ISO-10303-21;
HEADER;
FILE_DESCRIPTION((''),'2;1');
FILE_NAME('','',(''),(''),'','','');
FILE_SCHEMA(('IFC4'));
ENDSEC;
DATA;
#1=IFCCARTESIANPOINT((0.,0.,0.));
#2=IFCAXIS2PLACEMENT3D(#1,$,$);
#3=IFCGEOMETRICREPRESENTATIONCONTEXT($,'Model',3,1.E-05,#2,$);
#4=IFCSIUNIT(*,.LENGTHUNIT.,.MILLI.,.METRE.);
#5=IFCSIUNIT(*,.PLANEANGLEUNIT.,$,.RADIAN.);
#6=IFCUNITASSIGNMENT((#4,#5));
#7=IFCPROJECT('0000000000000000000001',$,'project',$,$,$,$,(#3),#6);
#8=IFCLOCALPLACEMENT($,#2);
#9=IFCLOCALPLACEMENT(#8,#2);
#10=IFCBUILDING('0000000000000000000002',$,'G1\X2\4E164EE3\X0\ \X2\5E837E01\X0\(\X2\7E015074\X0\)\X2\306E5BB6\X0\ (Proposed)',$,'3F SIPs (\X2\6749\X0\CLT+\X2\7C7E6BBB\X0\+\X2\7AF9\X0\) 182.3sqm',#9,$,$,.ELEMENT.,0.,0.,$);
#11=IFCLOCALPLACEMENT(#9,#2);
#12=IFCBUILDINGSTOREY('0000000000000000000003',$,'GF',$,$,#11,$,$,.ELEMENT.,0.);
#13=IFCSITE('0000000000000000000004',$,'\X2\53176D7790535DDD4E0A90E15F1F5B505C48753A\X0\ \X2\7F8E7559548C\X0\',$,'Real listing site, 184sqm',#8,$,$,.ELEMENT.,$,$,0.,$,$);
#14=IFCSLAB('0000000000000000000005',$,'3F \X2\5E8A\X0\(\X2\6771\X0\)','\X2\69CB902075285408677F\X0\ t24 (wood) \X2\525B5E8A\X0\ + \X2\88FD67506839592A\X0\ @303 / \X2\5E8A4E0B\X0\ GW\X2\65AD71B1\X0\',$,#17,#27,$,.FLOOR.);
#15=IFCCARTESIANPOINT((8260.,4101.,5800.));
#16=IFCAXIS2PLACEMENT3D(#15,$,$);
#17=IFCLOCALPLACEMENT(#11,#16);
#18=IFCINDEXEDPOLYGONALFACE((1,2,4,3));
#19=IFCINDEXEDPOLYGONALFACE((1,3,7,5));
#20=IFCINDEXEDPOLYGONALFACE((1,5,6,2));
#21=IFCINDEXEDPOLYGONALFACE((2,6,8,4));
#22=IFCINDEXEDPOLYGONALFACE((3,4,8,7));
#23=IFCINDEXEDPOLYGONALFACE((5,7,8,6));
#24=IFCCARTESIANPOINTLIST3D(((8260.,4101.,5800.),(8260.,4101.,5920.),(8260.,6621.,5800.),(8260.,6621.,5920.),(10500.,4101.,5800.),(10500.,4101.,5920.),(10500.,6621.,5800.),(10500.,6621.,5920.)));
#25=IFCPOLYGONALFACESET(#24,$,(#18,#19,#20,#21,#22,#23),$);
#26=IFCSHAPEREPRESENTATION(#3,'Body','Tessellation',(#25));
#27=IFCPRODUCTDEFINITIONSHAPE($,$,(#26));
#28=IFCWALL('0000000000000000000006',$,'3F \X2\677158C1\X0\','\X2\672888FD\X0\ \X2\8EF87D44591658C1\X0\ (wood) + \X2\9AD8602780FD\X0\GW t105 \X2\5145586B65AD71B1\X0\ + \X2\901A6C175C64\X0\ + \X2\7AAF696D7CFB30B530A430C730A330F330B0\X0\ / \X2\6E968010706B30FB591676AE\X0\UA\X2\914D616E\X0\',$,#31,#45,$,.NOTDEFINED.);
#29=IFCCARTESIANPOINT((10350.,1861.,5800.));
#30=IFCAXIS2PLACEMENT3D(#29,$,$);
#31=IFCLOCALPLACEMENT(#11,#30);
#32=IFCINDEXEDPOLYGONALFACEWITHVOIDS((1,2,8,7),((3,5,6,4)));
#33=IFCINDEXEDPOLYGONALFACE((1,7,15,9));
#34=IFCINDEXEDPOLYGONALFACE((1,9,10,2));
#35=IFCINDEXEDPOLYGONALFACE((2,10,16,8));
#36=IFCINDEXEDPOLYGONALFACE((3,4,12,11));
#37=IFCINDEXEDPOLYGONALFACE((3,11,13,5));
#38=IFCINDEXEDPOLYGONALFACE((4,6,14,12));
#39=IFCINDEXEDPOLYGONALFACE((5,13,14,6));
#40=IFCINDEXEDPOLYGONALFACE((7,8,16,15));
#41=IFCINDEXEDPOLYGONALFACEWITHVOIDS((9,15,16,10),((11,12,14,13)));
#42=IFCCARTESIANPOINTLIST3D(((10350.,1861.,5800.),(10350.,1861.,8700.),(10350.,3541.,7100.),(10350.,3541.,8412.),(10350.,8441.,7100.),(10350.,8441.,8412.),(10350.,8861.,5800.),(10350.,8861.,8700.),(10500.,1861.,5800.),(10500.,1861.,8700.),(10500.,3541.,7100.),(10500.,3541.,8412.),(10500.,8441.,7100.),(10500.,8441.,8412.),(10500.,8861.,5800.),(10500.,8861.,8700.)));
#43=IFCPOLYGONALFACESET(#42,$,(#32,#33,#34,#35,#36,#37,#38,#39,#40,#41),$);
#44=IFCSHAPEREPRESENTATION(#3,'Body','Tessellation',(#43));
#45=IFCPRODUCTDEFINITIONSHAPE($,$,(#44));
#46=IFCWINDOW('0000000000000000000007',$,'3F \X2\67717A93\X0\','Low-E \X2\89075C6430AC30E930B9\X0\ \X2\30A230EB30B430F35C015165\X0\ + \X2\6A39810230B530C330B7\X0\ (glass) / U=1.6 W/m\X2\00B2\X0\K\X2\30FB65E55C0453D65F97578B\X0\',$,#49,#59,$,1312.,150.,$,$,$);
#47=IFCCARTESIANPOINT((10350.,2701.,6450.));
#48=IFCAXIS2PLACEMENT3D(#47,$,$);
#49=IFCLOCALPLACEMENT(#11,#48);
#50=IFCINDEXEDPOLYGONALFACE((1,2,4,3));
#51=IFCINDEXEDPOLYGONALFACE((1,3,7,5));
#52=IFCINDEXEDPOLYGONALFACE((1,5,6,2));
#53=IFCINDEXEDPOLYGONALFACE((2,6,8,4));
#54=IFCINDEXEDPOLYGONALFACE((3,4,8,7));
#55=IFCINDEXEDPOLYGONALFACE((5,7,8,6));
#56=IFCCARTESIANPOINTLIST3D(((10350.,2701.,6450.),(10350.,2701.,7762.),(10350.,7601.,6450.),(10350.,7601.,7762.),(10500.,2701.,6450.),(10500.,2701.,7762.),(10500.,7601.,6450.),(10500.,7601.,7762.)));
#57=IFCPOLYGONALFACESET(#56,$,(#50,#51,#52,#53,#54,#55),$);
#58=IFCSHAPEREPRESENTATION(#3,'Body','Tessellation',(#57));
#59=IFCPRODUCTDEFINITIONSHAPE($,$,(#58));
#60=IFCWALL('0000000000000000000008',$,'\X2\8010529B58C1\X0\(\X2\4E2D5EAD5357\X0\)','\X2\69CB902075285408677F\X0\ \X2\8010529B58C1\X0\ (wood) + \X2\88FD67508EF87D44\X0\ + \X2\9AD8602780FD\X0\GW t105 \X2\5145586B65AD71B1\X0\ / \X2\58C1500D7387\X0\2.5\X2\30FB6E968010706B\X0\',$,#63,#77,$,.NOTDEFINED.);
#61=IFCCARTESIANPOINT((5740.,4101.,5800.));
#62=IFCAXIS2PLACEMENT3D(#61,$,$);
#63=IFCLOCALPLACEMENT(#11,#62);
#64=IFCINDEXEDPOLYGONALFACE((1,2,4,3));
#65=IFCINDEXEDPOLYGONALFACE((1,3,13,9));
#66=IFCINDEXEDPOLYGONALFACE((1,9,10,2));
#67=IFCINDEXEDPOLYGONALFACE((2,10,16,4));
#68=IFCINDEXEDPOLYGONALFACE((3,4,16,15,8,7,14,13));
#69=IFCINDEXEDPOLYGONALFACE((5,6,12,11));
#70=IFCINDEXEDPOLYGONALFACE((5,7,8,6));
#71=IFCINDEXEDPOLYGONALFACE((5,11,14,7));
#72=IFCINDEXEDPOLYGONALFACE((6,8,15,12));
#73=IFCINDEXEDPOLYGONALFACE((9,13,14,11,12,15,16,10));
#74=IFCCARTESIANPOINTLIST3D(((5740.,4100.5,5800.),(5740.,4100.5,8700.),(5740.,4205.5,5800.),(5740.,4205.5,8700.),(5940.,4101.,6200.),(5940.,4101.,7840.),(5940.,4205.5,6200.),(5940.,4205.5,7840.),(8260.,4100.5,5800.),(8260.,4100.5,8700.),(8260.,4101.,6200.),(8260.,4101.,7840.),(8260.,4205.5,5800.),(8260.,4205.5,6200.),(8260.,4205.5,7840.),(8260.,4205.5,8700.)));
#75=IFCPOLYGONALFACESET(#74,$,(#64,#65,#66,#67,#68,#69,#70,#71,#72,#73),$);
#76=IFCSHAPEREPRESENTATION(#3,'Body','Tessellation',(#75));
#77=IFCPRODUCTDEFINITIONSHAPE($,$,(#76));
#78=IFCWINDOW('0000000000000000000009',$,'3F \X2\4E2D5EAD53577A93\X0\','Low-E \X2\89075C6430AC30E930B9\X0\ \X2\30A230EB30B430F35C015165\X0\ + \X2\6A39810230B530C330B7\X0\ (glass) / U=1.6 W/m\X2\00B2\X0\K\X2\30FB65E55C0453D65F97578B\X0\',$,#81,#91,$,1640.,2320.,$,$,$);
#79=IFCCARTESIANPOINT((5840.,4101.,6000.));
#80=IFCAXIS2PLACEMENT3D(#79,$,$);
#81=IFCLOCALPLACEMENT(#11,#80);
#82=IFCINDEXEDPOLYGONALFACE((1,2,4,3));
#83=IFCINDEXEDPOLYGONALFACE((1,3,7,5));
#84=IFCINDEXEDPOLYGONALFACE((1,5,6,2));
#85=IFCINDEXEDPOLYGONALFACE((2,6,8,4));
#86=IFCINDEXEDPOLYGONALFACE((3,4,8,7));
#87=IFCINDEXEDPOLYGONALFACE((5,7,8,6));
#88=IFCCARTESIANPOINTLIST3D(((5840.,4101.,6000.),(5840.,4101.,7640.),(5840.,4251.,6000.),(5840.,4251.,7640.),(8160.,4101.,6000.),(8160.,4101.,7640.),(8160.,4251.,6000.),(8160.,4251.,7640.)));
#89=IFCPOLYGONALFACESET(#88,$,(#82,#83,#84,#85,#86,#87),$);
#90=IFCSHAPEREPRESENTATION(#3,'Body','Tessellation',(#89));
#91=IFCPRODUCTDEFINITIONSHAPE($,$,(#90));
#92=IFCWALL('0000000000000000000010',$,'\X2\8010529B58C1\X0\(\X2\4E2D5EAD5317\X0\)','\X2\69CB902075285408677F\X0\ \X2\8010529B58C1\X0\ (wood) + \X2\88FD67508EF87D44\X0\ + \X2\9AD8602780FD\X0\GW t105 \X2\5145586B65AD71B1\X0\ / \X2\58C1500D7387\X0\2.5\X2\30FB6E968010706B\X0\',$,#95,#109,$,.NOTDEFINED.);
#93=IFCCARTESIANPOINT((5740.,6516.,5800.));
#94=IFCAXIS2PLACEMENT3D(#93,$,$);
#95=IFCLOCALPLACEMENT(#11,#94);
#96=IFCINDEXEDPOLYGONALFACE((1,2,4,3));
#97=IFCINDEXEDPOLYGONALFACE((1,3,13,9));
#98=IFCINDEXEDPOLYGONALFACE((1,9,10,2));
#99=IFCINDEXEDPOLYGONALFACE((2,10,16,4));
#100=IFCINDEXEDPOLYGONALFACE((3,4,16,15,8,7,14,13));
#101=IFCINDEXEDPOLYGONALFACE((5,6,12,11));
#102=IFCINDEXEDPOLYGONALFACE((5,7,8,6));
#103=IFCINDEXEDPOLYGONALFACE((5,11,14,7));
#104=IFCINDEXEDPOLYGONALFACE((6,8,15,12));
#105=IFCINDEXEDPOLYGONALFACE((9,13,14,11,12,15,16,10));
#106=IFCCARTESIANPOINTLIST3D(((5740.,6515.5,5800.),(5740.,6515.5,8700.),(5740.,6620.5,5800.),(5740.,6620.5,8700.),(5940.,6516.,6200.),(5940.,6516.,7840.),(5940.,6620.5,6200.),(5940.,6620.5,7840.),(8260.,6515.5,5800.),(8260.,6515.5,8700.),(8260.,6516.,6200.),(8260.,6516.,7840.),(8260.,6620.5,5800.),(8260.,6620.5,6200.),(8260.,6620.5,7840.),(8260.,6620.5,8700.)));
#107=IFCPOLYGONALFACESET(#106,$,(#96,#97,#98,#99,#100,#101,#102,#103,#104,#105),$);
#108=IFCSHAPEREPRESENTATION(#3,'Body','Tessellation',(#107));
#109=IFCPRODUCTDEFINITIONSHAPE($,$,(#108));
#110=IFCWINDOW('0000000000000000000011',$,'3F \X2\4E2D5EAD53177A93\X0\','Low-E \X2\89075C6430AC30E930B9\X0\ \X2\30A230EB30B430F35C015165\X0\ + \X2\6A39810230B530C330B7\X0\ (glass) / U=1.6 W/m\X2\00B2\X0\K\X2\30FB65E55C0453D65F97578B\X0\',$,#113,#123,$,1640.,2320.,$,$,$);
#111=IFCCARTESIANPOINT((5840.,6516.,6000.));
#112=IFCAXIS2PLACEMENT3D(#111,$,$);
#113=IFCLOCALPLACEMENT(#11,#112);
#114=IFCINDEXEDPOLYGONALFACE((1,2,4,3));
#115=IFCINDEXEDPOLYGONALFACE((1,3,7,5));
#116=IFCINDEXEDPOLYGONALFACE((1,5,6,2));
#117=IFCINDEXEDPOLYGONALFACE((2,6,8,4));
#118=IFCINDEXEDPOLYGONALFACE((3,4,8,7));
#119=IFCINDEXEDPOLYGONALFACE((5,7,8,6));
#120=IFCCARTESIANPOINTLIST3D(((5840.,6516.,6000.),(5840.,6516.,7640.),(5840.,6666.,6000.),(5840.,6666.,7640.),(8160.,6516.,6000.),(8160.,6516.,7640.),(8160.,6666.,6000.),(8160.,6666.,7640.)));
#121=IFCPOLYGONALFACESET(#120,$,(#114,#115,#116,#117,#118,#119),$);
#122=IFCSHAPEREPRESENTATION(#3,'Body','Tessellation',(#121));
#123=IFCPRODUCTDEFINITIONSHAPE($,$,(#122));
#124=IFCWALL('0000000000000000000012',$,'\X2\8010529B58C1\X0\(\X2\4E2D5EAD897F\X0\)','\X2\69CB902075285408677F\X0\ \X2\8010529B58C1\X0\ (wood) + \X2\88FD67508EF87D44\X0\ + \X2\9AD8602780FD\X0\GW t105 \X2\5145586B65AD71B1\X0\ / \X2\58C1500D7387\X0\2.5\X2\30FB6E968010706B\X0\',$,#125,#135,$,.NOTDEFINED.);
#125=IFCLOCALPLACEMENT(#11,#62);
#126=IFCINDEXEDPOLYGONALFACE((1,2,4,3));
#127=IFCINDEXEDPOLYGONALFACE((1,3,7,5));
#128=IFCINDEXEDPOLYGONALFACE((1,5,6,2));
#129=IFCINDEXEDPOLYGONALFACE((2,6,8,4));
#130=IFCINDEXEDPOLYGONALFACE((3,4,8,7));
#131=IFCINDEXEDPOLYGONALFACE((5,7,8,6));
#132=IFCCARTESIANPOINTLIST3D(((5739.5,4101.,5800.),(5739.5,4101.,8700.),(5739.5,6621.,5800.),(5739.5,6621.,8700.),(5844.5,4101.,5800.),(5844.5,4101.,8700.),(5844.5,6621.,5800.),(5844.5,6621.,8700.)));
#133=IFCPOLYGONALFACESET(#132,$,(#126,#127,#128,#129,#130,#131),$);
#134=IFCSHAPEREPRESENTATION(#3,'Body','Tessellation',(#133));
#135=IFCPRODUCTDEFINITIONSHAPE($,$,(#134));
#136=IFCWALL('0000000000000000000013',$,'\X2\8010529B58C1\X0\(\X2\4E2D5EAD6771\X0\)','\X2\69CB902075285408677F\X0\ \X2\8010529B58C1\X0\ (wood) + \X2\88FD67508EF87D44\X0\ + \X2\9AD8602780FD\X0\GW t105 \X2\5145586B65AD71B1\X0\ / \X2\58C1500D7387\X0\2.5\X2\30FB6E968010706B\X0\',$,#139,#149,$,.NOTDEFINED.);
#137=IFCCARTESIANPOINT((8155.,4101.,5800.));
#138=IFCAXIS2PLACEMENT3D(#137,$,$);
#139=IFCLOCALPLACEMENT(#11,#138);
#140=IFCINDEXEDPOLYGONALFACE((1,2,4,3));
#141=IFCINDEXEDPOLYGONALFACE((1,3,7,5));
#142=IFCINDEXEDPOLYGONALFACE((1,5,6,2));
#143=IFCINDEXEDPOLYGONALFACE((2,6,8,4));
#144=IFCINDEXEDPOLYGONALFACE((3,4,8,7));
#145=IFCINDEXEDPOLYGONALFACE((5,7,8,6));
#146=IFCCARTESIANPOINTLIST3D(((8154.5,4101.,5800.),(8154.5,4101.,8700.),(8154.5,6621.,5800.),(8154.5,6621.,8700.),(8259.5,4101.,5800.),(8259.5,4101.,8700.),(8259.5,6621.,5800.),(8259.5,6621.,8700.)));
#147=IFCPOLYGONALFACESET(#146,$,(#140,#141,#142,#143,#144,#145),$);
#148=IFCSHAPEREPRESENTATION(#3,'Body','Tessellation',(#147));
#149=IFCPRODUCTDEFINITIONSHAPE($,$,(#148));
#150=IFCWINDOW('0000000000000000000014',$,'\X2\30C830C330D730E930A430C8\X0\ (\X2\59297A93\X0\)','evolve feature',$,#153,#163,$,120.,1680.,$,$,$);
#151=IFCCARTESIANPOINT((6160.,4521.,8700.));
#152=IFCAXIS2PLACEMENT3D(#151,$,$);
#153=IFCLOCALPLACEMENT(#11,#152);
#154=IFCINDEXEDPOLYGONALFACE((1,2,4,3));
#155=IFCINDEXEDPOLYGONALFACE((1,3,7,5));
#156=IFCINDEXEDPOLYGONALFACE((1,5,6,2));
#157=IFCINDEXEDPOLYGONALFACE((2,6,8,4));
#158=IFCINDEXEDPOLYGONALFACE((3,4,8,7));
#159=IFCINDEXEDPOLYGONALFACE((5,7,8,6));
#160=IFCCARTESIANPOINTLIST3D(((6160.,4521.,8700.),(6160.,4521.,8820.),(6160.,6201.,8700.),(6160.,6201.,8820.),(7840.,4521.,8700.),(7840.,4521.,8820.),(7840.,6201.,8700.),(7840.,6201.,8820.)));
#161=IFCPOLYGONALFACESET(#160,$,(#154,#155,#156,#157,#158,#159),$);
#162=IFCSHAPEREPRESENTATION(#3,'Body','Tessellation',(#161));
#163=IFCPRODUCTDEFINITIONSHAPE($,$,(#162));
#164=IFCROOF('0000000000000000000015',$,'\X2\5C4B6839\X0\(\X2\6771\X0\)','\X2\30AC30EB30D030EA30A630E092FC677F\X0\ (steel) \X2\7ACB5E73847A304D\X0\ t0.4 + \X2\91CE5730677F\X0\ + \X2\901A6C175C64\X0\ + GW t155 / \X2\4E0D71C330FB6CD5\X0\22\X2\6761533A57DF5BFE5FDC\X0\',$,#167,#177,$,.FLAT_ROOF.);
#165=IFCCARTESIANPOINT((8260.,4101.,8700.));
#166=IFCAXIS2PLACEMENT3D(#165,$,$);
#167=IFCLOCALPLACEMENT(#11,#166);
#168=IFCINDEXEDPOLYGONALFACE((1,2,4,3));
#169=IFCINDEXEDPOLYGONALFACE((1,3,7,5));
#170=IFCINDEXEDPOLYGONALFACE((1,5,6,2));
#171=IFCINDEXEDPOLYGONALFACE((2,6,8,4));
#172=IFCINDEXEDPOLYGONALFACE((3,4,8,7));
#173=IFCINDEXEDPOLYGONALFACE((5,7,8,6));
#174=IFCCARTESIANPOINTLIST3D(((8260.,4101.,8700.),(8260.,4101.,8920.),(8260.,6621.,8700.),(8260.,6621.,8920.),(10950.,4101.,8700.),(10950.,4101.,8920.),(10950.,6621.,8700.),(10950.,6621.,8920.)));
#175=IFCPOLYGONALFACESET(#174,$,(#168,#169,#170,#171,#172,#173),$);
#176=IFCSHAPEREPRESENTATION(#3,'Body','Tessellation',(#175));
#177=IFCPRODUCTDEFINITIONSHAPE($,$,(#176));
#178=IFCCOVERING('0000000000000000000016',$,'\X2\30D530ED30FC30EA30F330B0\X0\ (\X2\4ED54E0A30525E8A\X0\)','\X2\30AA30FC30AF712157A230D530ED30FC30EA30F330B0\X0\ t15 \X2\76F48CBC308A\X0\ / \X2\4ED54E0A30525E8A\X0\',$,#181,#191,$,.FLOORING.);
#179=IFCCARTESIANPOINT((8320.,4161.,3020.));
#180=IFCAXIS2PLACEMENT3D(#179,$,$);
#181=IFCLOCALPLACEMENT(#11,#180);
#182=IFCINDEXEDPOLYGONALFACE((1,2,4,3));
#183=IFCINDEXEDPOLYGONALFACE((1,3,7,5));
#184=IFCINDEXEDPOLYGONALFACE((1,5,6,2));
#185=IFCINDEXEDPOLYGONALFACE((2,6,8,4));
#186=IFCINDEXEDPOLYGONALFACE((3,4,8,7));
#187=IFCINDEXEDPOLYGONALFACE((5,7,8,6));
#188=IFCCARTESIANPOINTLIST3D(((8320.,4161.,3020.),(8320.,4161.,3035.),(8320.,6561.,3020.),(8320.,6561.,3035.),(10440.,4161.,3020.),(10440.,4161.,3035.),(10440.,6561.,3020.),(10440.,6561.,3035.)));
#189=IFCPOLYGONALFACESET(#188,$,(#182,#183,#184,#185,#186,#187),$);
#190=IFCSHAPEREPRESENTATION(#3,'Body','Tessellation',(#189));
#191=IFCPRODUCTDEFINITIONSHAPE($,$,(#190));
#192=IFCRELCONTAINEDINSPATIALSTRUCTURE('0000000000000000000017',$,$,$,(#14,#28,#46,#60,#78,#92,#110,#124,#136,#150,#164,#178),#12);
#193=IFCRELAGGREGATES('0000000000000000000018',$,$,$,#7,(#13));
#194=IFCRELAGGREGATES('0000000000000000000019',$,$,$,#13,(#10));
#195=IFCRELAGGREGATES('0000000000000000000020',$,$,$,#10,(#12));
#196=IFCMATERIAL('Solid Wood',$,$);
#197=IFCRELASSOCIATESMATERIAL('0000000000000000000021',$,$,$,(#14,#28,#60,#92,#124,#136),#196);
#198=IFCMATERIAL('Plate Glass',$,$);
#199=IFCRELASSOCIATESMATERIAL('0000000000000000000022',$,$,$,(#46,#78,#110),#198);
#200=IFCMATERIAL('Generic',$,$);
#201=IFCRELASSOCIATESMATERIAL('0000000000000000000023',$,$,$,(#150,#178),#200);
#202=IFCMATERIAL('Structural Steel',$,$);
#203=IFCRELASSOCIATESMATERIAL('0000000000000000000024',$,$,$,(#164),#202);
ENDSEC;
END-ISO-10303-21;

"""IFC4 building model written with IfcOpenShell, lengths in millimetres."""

from ifc_helpers import new_model, si_unit, frame, frame_2d, origin, place, context, project, spatial, rectangle, extrude, material, element, fill, save


model = new_model("IFC4")

# Units and contexts
model_context = context("Model", 3, precision=1e-05, world=origin())
ifc_project = project(units=[si_unit("LENGTHUNIT", "METRE", prefix="MILLI"), si_unit("PLANEANGLEUNIT", "RADIAN")], contexts=[model_context])

# Site, building, storey
site_placement = place(None, origin())
site = spatial("IfcSite", under=ifc_project, at=site_placement, Name="北海道川上郡弟子屈町 美留和", ObjectType="Real listing site, 184sqm", CompositionType="ELEMENT", RefElevation=0.0)
building_placement = place(site_placement, origin())
building = spatial("IfcBuilding", under=site, at=building_placement, Name="G1世代 広縁(縁側)の家 (Proposed)", ObjectType="3F SIPs (杉CLT+籾殻+竹) 182.3sqm", CompositionType="ELEMENT", ElevationOfRefHeight=0.0, ElevationOfTerrain=0.0)
storey_placement = place(building_placement, origin())
storey = spatial("IfcBuildingStorey", under=building, at=storey_placement, Name="GF", CompositionType="ELEMENT", Elevation=0.0)

# Slab
ifc_material_1 = material(Name="Solid Wood")
slab_placement = place(storey_placement, frame((8260.0, 4101.0, 5800.0)))
element("IfcSlab", 1, at=slab_placement, inside=storey, material=ifc_material_1, Name="3F 床(東)", Description="構造用合板 t24 (wood) 剛床 + 製材根太 @303 / 床下 GW断熱", PredefinedType="FLOOR", context=model_context, shape_type="SweptSolid", body=[
    extrude(rectangle(XDim=2240.0, YDim=2520.0, at=frame_2d((1120.0, 1260.0))), frame((8260.0, 4101.0, 5800.0)), (0.0, 0.0, 1.0), 120.0),
])

# Walls, openings, windows
wall_1_placement = place(storey_placement, frame((10350.0, 1861.0, 5800.0)))
wall_1 = element("IfcWall", 2, at=wall_1_placement, inside=storey, material=ifc_material_1, Name="3F 東壁", Description="木製 軸組外壁 (wood) + 高性能GW t105 充填断熱 + 通気層 + 窯業系サイディング / 準耐火・外皮UA配慮", PredefinedType="NOTDEFINED", context=model_context, shape_type="SweptSolid", body=[
    extrude(rectangle(XDim=150.0, YDim=7000.0, at=frame_2d((75.0, 3500.0))), frame((10350.0, 1861.0, 5800.0)), (0.0, 0.0, 1.0), 2900.0),
])
opening_1_placement = place(storey_placement, frame((10350.0, 2701.0, 6450.0)))
opening_1 = element("IfcOpeningElement", 3, at=opening_1_placement, cuts=wall_1, PredefinedType="NOTDEFINED", context=model_context, shape_type="SweptSolid", body=[
    extrude(rectangle(XDim=150.0, YDim=4900.0, at=frame_2d((75.0, 2450.0))), frame((10350.0, 2701.0, 6450.0)), (0.0, 0.0, 1.0), 1312.0),
])
ifc_material_2 = material(Name="Plate Glass")
window_1_placement = place(storey_placement, frame((10350.0, 2701.0, 6450.0)))
window_1 = element("IfcWindow", 4, at=window_1_placement, inside=storey, material=ifc_material_2, Name="3F 東窓", Description="Low-E 複層ガラス アルゴン封入 + 樹脂サッシ (glass) / U=1.6 W/m²K・日射取得型", OverallHeight=1312.0, OverallWidth=150.0, context=model_context, shape_type="SweptSolid", body=[
    extrude(rectangle(XDim=150.0, YDim=4900.0, at=frame_2d((75.0, 2450.0))), frame((10350.0, 2701.0, 6450.0)), (0.0, 0.0, 1.0), 1312.0),
])
fill(opening_1, window_1)
wall_2_placement = place(storey_placement, frame((5740.0, 4101.0, 5800.0)))
wall_2 = element("IfcWall", 5, at=wall_2_placement, inside=storey, material=ifc_material_1, Name="耐力壁(中庭南)", Description="構造用合板 耐力壁 (wood) + 製材軸組 + 高性能GW t105 充填断熱 / 壁倍率2.5・準耐火", PredefinedType="NOTDEFINED", context=model_context, shape_type="SweptSolid", body=[
    extrude(rectangle(XDim=2520.0, YDim=105.0, at=frame_2d((1260.0, 52.0))), frame((5740.0, 4101.0, 5800.0)), (0.0, 0.0, 1.0), 2900.0),
])
opening_2_placement = place(storey_placement, frame((5840.0, 4101.0, 6000.0)))
opening_2 = element("IfcOpeningElement", 6, at=opening_2_placement, cuts=wall_2, PredefinedType="NOTDEFINED", context=model_context, shape_type="SweptSolid", body=[
    extrude(rectangle(XDim=2320.0, YDim=150.0, at=frame_2d((1160.0, 75.0))), frame((5840.0, 4101.0, 6000.0)), (0.0, 0.0, 1.0), 1640.0),
])
window_2_placement = place(storey_placement, frame((5840.0, 4101.0, 6000.0)))
window_2 = element("IfcWindow", 7, at=window_2_placement, inside=storey, material=ifc_material_2, Name="3F 中庭南窓", Description="Low-E 複層ガラス アルゴン封入 + 樹脂サッシ (glass) / U=1.6 W/m²K・日射取得型", OverallHeight=1640.0, OverallWidth=2320.0, context=model_context, shape_type="SweptSolid", body=[
    extrude(rectangle(XDim=2320.0, YDim=150.0, at=frame_2d((1160.0, 75.0))), frame((5840.0, 4101.0, 6000.0)), (0.0, 0.0, 1.0), 1640.0),
])
fill(opening_2, window_2)
wall_3_placement = place(storey_placement, frame((5740.0, 6516.0, 5800.0)))
wall_3 = element("IfcWall", 8, at=wall_3_placement, inside=storey, material=ifc_material_1, Name="耐力壁(中庭北)", Description="構造用合板 耐力壁 (wood) + 製材軸組 + 高性能GW t105 充填断熱 / 壁倍率2.5・準耐火", PredefinedType="NOTDEFINED", context=model_context, shape_type="SweptSolid", body=[
    extrude(rectangle(XDim=2520.0, YDim=105.0, at=frame_2d((1260.0, 52.0))), frame((5740.0, 6516.0, 5800.0)), (0.0, 0.0, 1.0), 2900.0),
])
opening_3_placement = place(storey_placement, frame((5840.0, 6516.0, 6000.0)))
opening_3 = element("IfcOpeningElement", 9, at=opening_3_placement, cuts=wall_3, PredefinedType="NOTDEFINED", context=model_context, shape_type="SweptSolid", body=[
    extrude(rectangle(XDim=2320.0, YDim=150.0, at=frame_2d((1160.0, 75.0))), frame((5840.0, 6516.0, 6000.0)), (0.0, 0.0, 1.0), 1640.0),
])
window_3_placement = place(storey_placement, frame((5840.0, 6516.0, 6000.0)))
window_3 = element("IfcWindow", 10, at=window_3_placement, inside=storey, material=ifc_material_2, Name="3F 中庭北窓", Description="Low-E 複層ガラス アルゴン封入 + 樹脂サッシ (glass) / U=1.6 W/m²K・日射取得型", OverallHeight=1640.0, OverallWidth=2320.0, context=model_context, shape_type="SweptSolid", body=[
    extrude(rectangle(XDim=2320.0, YDim=150.0, at=frame_2d((1160.0, 75.0))), frame((5840.0, 6516.0, 6000.0)), (0.0, 0.0, 1.0), 1640.0),
])
fill(opening_3, window_3)

# Walls
wall_4_placement = place(storey_placement, frame((5740.0, 4101.0, 5800.0)))
element("IfcWall", 11, at=wall_4_placement, inside=storey, material=ifc_material_1, Name="耐力壁(中庭西)", Description="構造用合板 耐力壁 (wood) + 製材軸組 + 高性能GW t105 充填断熱 / 壁倍率2.5・準耐火", PredefinedType="NOTDEFINED", context=model_context, shape_type="SweptSolid", body=[
    extrude(rectangle(XDim=105.0, YDim=2520.0, at=frame_2d((52.0, 1260.0))), frame((5740.0, 4101.0, 5800.0)), (0.0, 0.0, 1.0), 2900.0),
])
wall_5_placement = place(storey_placement, frame((8155.0, 4101.0, 5800.0)))
element("IfcWall", 12, at=wall_5_placement, inside=storey, material=ifc_material_1, Name="耐力壁(中庭東)", Description="構造用合板 耐力壁 (wood) + 製材軸組 + 高性能GW t105 充填断熱 / 壁倍率2.5・準耐火", PredefinedType="NOTDEFINED", context=model_context, shape_type="SweptSolid", body=[
    extrude(rectangle(XDim=105.0, YDim=2520.0, at=frame_2d((52.0, 1260.0))), frame((8155.0, 4101.0, 5800.0)), (0.0, 0.0, 1.0), 2900.0),
])

# Window
ifc_material_3 = material(Name="Generic")
window_4_placement = place(storey_placement, frame((6160.0, 4521.0, 8700.0)))
element("IfcWindow", 13, at=window_4_placement, inside=storey, material=ifc_material_3, Name="トップライト (天窓)", Description="evolve feature", OverallHeight=120.0, OverallWidth=1680.0, context=model_context, shape_type="SweptSolid", body=[
    extrude(rectangle(XDim=1680.0, YDim=1680.0, at=frame_2d((840.0, 840.0))), frame((6160.0, 4521.0, 8700.0)), (0.0, 0.0, 1.0), 120.0),
])

# Roof
ifc_material_4 = material(Name="Structural Steel")
for number, where, name in (
    (14, (8260.0, 4101.0, 8700.0), "屋根(東)"),
):
    element("IfcRoof", number, at=place(storey_placement, frame(where)), inside=storey, material=ifc_material_4, Name=name, Description="ガルバリウム鋼板 (steel) 立平葺き t0.4 + 野地板 + 通気層 + GW t155 / 不燃・法22条区域対応", PredefinedType="FLAT_ROOF", context=model_context, shape_type="SweptSolid", body=[
        extrude(rectangle(XDim=2690.0, YDim=2520.0, at=frame_2d((1345.0, 1260.0))), frame((8260.0, 4101.0, 8700.0)), (0.0, 0.0, 1.0), 220.0),
    ])

# Covering
covering_1_placement = place(storey_placement, frame((8320.0, 4161.0, 3020.0)))
element("IfcCovering", 15, at=covering_1_placement, inside=storey, material=ifc_material_3, Name="フローリング (仕上げ床)", Description="オーク無垢フローリング t15 直貼り / 仕上げ床", PredefinedType="FLOORING", context=model_context, shape_type="SweptSolid", body=[
    extrude(rectangle(XDim=2120.0, YDim=2400.0, at=frame_2d((1060.0, 1200.0))), frame((8320.0, 4161.0, 3020.0)), (0.0, 0.0, 1.0), 15.0),
])

save(model, "model.ifc")
